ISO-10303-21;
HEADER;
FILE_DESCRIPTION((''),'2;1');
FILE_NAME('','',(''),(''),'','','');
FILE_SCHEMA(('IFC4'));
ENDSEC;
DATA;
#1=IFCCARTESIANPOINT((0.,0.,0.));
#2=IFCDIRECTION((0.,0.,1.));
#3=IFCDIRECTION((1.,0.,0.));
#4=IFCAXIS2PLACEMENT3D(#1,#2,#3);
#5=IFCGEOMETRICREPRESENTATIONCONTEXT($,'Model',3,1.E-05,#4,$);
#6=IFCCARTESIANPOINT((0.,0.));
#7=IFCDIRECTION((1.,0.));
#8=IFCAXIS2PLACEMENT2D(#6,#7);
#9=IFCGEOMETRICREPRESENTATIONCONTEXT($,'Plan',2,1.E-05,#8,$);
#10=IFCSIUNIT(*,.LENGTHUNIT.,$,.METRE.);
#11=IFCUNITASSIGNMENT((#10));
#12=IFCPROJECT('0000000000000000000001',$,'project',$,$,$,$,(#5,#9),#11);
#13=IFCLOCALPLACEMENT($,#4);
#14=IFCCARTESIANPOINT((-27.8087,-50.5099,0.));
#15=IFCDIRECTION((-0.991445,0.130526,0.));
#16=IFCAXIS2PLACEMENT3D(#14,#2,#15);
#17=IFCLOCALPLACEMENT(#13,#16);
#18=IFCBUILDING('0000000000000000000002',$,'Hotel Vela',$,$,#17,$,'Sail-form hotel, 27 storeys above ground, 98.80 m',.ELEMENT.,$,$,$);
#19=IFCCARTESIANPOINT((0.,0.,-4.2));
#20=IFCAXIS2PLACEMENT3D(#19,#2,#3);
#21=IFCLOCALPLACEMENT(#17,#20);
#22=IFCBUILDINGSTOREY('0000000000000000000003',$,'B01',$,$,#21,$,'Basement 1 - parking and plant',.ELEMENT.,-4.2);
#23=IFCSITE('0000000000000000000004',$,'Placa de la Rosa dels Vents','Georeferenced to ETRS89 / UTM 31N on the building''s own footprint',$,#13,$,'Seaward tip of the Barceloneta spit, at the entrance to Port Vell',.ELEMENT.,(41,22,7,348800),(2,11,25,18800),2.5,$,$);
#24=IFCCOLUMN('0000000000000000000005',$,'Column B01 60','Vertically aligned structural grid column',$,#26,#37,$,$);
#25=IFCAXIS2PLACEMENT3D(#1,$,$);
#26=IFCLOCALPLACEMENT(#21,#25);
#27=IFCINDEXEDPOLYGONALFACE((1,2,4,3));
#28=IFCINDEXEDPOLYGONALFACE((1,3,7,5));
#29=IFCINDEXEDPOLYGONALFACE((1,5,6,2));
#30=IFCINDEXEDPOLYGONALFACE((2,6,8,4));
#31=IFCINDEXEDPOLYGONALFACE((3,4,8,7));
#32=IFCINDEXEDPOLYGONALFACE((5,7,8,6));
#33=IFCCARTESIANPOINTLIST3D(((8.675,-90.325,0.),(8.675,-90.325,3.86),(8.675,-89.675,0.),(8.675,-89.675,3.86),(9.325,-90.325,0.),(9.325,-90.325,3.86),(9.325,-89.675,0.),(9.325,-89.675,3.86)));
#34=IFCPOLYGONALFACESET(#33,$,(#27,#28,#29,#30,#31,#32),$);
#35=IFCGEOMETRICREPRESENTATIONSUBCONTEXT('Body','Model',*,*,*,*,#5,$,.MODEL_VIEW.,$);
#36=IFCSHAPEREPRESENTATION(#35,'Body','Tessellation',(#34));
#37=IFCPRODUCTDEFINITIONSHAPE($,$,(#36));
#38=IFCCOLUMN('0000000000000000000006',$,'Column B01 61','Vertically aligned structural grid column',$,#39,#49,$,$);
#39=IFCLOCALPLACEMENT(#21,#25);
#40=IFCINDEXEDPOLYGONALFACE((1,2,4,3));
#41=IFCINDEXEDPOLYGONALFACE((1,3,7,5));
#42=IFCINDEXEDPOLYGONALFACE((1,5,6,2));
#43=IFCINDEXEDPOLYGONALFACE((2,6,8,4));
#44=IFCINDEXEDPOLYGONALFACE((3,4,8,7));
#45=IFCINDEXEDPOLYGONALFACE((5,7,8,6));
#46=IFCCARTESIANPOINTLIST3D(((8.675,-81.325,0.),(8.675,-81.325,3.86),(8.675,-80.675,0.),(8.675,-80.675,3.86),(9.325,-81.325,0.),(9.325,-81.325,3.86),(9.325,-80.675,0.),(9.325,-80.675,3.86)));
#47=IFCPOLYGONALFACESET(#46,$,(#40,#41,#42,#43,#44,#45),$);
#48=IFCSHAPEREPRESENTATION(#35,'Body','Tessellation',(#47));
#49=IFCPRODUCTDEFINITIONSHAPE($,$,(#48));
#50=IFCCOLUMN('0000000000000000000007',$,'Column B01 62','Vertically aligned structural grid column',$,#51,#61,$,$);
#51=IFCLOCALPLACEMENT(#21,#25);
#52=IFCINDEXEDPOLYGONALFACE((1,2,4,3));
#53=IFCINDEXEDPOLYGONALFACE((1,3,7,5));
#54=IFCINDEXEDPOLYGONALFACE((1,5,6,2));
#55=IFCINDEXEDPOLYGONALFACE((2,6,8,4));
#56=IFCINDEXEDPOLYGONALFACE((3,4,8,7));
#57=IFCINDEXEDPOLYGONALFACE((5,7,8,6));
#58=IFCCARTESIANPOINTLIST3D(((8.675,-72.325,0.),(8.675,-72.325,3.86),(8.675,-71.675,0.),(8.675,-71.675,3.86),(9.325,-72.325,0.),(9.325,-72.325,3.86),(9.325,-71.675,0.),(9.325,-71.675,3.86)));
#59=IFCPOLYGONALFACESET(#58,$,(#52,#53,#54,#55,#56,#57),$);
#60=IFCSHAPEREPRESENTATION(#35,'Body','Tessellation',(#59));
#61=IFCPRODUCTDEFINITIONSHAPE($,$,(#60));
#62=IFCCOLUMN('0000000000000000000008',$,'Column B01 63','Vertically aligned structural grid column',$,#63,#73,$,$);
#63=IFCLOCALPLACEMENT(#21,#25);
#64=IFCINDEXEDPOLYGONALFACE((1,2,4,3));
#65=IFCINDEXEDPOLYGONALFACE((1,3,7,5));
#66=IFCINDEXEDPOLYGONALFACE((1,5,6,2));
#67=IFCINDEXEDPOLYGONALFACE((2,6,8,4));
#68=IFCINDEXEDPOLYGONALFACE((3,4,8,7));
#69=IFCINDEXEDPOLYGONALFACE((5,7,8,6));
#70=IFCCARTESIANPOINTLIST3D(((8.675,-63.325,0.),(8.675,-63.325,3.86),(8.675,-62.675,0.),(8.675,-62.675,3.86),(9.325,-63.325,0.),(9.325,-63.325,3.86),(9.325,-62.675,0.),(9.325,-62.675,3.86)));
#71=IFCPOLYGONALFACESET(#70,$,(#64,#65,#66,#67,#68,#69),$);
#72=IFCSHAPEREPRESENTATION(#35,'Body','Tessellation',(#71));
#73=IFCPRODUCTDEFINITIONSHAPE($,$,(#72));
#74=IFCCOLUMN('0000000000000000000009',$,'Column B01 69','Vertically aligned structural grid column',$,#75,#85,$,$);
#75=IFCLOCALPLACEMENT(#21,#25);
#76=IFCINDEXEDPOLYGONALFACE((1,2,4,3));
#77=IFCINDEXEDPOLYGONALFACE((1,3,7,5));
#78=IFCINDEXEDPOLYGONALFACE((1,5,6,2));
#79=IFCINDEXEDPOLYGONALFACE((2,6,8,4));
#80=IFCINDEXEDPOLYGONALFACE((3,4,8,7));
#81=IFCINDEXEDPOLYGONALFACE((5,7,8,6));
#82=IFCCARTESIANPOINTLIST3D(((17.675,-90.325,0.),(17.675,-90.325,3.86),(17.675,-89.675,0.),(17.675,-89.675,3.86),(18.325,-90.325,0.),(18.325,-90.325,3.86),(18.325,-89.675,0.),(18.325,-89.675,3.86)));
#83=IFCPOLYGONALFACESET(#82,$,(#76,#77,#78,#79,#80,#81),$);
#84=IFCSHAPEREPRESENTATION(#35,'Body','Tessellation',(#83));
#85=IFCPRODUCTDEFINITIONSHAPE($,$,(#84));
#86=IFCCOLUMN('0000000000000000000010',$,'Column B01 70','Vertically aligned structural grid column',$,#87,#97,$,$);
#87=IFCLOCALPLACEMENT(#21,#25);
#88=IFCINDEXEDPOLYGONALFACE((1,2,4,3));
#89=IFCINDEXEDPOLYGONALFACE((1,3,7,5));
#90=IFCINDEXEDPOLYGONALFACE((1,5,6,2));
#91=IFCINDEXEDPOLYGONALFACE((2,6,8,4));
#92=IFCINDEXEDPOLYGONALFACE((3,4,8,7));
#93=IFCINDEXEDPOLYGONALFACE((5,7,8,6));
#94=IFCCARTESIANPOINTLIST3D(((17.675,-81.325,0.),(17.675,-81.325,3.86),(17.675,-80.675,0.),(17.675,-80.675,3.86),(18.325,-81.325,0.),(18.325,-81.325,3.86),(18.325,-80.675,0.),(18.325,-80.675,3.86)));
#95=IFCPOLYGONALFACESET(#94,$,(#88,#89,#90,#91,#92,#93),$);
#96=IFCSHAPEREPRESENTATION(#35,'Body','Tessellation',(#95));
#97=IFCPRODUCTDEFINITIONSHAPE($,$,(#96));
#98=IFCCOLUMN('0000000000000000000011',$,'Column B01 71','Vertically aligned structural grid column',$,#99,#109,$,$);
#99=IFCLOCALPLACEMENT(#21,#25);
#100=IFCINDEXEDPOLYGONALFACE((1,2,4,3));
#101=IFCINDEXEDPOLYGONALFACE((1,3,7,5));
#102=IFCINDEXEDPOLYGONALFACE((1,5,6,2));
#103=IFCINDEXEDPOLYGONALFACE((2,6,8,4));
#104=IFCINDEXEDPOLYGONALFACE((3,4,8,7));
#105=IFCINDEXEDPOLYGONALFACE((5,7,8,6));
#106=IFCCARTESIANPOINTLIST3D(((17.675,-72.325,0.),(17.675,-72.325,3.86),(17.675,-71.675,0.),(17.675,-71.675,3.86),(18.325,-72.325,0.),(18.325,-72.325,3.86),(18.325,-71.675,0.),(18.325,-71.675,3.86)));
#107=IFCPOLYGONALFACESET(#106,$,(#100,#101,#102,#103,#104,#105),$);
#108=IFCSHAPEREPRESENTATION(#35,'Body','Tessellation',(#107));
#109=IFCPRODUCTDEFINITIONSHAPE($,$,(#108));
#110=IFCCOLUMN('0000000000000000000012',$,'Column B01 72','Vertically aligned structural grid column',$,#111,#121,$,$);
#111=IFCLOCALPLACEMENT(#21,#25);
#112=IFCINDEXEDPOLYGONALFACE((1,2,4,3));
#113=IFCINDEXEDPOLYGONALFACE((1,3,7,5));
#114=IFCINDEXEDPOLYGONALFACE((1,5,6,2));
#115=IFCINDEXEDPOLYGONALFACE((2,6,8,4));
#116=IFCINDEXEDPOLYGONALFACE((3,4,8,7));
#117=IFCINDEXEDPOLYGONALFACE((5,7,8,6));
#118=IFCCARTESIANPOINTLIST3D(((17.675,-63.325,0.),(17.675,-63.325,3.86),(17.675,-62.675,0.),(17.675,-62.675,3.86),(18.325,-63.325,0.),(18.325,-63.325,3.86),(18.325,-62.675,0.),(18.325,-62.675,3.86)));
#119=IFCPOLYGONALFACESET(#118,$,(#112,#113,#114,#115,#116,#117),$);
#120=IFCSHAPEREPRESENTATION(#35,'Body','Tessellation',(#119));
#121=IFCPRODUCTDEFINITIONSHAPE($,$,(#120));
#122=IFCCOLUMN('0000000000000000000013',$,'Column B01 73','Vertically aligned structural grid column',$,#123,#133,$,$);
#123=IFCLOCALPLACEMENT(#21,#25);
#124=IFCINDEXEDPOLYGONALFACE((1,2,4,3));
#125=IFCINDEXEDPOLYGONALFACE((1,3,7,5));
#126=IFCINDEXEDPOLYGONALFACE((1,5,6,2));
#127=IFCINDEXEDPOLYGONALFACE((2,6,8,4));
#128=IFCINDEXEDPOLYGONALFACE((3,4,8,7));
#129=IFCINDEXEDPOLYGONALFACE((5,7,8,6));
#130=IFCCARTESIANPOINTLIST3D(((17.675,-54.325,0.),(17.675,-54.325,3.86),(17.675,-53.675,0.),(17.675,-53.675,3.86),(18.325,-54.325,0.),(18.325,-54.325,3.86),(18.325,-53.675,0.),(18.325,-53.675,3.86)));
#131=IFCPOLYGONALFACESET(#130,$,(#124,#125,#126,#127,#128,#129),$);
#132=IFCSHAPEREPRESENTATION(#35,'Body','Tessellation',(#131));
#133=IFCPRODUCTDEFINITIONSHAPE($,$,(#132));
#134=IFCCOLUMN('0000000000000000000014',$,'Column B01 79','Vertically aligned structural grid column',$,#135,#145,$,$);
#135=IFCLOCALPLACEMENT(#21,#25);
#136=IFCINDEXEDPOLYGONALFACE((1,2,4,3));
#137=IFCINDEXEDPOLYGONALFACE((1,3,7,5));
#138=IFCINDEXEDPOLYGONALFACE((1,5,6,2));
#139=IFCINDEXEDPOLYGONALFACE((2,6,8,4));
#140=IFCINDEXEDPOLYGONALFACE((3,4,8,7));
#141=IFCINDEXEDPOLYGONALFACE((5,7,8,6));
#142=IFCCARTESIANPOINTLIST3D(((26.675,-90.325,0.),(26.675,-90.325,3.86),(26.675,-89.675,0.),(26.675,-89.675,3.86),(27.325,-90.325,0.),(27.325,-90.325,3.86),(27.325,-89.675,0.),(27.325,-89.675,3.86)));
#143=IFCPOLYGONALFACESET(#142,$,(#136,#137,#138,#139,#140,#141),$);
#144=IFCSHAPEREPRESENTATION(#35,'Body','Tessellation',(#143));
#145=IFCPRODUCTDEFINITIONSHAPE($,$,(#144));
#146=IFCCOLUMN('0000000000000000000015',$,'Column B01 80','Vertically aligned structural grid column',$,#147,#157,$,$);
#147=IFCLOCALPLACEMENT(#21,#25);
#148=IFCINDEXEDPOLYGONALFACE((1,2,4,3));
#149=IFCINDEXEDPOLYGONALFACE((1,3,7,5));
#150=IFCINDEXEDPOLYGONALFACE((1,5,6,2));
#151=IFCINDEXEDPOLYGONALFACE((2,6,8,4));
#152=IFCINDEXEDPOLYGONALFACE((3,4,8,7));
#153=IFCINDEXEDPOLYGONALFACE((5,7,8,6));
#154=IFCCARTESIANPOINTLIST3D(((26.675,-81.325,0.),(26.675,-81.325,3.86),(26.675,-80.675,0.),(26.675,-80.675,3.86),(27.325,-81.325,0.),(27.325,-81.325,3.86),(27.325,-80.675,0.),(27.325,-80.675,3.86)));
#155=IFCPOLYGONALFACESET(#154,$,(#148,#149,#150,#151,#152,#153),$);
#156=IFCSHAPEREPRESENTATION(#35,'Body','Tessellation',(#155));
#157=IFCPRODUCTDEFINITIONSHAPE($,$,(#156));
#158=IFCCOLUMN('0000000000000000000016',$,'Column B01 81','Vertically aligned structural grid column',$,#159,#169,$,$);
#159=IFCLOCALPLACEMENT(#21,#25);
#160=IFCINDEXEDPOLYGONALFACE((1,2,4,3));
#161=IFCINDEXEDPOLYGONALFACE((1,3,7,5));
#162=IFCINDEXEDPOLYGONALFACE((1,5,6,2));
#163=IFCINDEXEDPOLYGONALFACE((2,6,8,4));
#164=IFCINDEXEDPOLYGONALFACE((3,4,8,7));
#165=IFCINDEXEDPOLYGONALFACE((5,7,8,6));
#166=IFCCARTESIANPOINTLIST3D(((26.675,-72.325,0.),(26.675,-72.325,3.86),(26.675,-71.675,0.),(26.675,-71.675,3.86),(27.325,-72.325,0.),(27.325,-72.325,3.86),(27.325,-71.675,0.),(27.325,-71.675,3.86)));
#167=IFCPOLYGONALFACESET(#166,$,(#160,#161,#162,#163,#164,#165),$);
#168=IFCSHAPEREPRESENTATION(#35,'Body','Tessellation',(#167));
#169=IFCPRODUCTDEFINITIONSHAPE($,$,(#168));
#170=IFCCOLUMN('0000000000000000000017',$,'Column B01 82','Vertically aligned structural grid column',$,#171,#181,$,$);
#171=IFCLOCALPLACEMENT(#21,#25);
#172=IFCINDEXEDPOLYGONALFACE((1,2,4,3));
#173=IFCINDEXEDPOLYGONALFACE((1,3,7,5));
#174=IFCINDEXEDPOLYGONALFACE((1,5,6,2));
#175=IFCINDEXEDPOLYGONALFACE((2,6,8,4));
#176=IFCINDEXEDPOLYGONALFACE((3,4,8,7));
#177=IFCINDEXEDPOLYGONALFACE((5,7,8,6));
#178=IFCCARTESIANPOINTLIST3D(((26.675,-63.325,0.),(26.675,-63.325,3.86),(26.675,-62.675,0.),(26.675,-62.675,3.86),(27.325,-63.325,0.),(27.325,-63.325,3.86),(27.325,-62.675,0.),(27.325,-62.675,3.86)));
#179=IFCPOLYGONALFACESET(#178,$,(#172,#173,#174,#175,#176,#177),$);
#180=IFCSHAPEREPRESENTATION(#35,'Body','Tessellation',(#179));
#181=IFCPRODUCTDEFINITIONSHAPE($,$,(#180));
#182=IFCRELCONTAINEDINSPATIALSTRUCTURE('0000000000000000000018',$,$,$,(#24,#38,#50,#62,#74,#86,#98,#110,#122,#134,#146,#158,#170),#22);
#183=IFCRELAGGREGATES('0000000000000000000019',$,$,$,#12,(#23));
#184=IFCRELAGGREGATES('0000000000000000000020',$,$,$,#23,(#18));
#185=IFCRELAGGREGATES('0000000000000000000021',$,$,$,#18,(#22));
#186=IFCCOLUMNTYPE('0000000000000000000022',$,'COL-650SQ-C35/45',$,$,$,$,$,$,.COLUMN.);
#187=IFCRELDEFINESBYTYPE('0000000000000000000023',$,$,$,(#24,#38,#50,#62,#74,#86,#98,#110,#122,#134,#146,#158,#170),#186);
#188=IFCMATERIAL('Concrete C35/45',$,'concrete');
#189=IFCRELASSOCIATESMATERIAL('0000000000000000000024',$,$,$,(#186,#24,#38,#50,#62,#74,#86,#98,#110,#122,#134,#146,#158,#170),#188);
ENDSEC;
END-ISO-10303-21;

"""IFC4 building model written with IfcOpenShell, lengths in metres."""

from ifc_helpers import new_model, si_unit, frame, origin_with_axes, origin_2d_with_axis, place, context, subcontext, project, spatial, line, indexed_curve, rectangle, outline, extrude, material, material_profile, profile_set, profile_usage, type_object, element, save


model = new_model("IFC4")

# Units and contexts
model_context = context("Model", 3, precision=1e-05, world=origin_with_axes())
plan_context = context("Plan", 2, precision=1e-05, world=origin_2d_with_axis())
body_context = subcontext(model_context, "Body", "Model", "MODEL_VIEW")
ifc_project = project(units=[si_unit("LENGTHUNIT", "METRE")], contexts=[model_context, plan_context])

# Site, building, storey
site_placement = place(None, origin_with_axes())
site = spatial("IfcSite", under=ifc_project, at=site_placement, Name="Placa de la Rosa dels Vents", Description="Georeferenced to ETRS89 / UTM 31N on the building's own footprint", LongName="Seaward tip of the Barceloneta spit, at the entrance to Port Vell", CompositionType="ELEMENT", RefLatitude=(41, 22, 7, 348800), RefLongitude=(2, 11, 25, 18800), RefElevation=2.5)
building_placement = place(site_placement, frame((-27.8087, -50.5099, 0.0), z_axis=(0.0, 0.0, 1.0), x_axis=(-0.991445, 0.130526, 0.0)))
building = spatial("IfcBuilding", under=site, at=building_placement, Name="Hotel Vela", LongName="Sail-form hotel, 27 storeys above ground, 98.80 m", CompositionType="ELEMENT")
storey_placement = place(building_placement, frame((0.0, 0.0, -4.2), z_axis=(0.0, 0.0, 1.0), x_axis=(1.0, 0.0, 0.0)))
storey = spatial("IfcBuildingStorey", under=building, at=storey_placement, Name="B01", LongName="Basement 1 - parking and plant", CompositionType="ELEMENT", Elevation=-4.2)

# Columns
ifc_material = material(Name="Concrete C35/45", Category="concrete")
ifc_material_profile = material_profile(ifc_material, rectangle(XDim=0.65, YDim=0.65))
ifc_profile_set = profile_set([ifc_material_profile], Name="COL-650SQ-C35/45")
ifc_profile_usage_1 = profile_usage(ifc_profile_set)
column_type = type_object("IfcColumnType", Name="COL-650SQ-C35/45", PredefinedType="COLUMN", material=ifc_profile_set)
column_1_placement = place(storey_placement, frame((8.675, -90.325, 0.0), z_axis=(0.0, 0.0, 1.0), x_axis=(1.0, 0.0, 0.0)))
element("IfcColumn", 1, at=column_1_placement, inside=storey, type_object=column_type, material=ifc_profile_usage_1, Name="Column B01 60", Description="Vertically aligned structural grid column", context=body_context, shape_type="SweptSolid", body=[
    extrude(outline(indexed_curve([(0.0, 0.0), (0.65, 0.0), (0.65, 0.65), (0.0, 0.65)], segments=[line(1, 2, 3, 4, 1)])), origin_with_axes(), (0.0, 0.0, 1.0), 3.86),
])
ifc_profile_usage_2 = profile_usage(ifc_profile_set)
column_2_placement = place(storey_placement, frame((8.675, -81.325, 0.0), z_axis=(0.0, 0.0, 1.0), x_axis=(1.0, 0.0, 0.0)))
element("IfcColumn", 2, at=column_2_placement, inside=storey, type_object=column_type, material=ifc_profile_usage_2, Name="Column B01 61", Description="Vertically aligned structural grid column", context=body_context, shape_type="SweptSolid", body=[
    extrude(outline(indexed_curve([(0.0, 0.0), (0.65, 0.0), (0.65, 0.65), (0.0, 0.65)], segments=[line(1, 2, 3, 4, 1)])), origin_with_axes(), (0.0, 0.0, 1.0), 3.86),
])
ifc_profile_usage_3 = profile_usage(ifc_profile_set)
column_3_placement = place(storey_placement, frame((8.675, -72.325, 0.0), z_axis=(0.0, 0.0, 1.0), x_axis=(1.0, 0.0, 0.0)))
element("IfcColumn", 3, at=column_3_placement, inside=storey, type_object=column_type, material=ifc_profile_usage_3, Name="Column B01 62", Description="Vertically aligned structural grid column", context=body_context, shape_type="SweptSolid", body=[
    extrude(outline(indexed_curve([(0.0, 0.0), (0.65, 0.0), (0.65, 0.65), (0.0, 0.65)], segments=[line(1, 2, 3, 4, 1)])), origin_with_axes(), (0.0, 0.0, 1.0), 3.86),
])
ifc_profile_usage_4 = profile_usage(ifc_profile_set)
column_4_placement = place(storey_placement, frame((8.675, -63.325, 0.0), z_axis=(0.0, 0.0, 1.0), x_axis=(1.0, 0.0, 0.0)))
element("IfcColumn", 4, at=column_4_placement, inside=storey, type_object=column_type, material=ifc_profile_usage_4, Name="Column B01 63", Description="Vertically aligned structural grid column", context=body_context, shape_type="SweptSolid", body=[
    extrude(outline(indexed_curve([(0.0, 0.0), (0.65, 0.0), (0.65, 0.65), (0.0, 0.65)], segments=[line(1, 2, 3, 4, 1)])), origin_with_axes(), (0.0, 0.0, 1.0), 3.86),
])
ifc_profile_usage_5 = profile_usage(ifc_profile_set)
column_5_placement = place(storey_placement, frame((17.675, -90.325, 0.0), z_axis=(0.0, 0.0, 1.0), x_axis=(1.0, 0.0, 0.0)))
element("IfcColumn", 5, at=column_5_placement, inside=storey, type_object=column_type, material=ifc_profile_usage_5, Name="Column B01 69", Description="Vertically aligned structural grid column", context=body_context, shape_type="SweptSolid", body=[
    extrude(outline(indexed_curve([(0.0, 0.0), (0.65, 0.0), (0.65, 0.65), (0.0, 0.65)], segments=[line(1, 2, 3, 4, 1)])), origin_with_axes(), (0.0, 0.0, 1.0), 3.86),
])
ifc_profile_usage_6 = profile_usage(ifc_profile_set)
column_6_placement = place(storey_placement, frame((17.675, -81.325, 0.0), z_axis=(0.0, 0.0, 1.0), x_axis=(1.0, 0.0, 0.0)))
element("IfcColumn", 6, at=column_6_placement, inside=storey, type_object=column_type, material=ifc_profile_usage_6, Name="Column B01 70", Description="Vertically aligned structural grid column", context=body_context, shape_type="SweptSolid", body=[
    extrude(outline(indexed_curve([(0.0, 0.0), (0.65, 0.0), (0.65, 0.65), (0.0, 0.65)], segments=[line(1, 2, 3, 4, 1)])), origin_with_axes(), (0.0, 0.0, 1.0), 3.86),
])
ifc_profile_usage_7 = profile_usage(ifc_profile_set)
column_7_placement = place(storey_placement, frame((17.675, -72.325, 0.0), z_axis=(0.0, 0.0, 1.0), x_axis=(1.0, 0.0, 0.0)))
element("IfcColumn", 7, at=column_7_placement, inside=storey, type_object=column_type, material=ifc_profile_usage_7, Name="Column B01 71", Description="Vertically aligned structural grid column", context=body_context, shape_type="SweptSolid", body=[
    extrude(outline(indexed_curve([(0.0, 0.0), (0.65, 0.0), (0.65, 0.65), (0.0, 0.65)], segments=[line(1, 2, 3, 4, 1)])), origin_with_axes(), (0.0, 0.0, 1.0), 3.86),
])
ifc_profile_usage_8 = profile_usage(ifc_profile_set)
column_8_placement = place(storey_placement, frame((17.675, -63.325, 0.0), z_axis=(0.0, 0.0, 1.0), x_axis=(1.0, 0.0, 0.0)))
element("IfcColumn", 8, at=column_8_placement, inside=storey, type_object=column_type, material=ifc_profile_usage_8, Name="Column B01 72", Description="Vertically aligned structural grid column", context=body_context, shape_type="SweptSolid", body=[
    extrude(outline(indexed_curve([(0.0, 0.0), (0.65, 0.0), (0.65, 0.65), (0.0, 0.65)], segments=[line(1, 2, 3, 4, 1)])), origin_with_axes(), (0.0, 0.0, 1.0), 3.86),
])
ifc_profile_usage_9 = profile_usage(ifc_profile_set)
column_9_placement = place(storey_placement, frame((17.675, -54.325, 0.0), z_axis=(0.0, 0.0, 1.0), x_axis=(1.0, 0.0, 0.0)))
element("IfcColumn", 9, at=column_9_placement, inside=storey, type_object=column_type, material=ifc_profile_usage_9, Name="Column B01 73", Description="Vertically aligned structural grid column", context=body_context, shape_type="SweptSolid", body=[
    extrude(outline(indexed_curve([(0.0, 0.0), (0.65, 0.0), (0.65, 0.65), (0.0, 0.65)], segments=[line(1, 2, 3, 4, 1)])), origin_with_axes(), (0.0, 0.0, 1.0), 3.86),
])
ifc_profile_usage_10 = profile_usage(ifc_profile_set)
column_10_placement = place(storey_placement, frame((26.675, -90.325, 0.0), z_axis=(0.0, 0.0, 1.0), x_axis=(1.0, 0.0, 0.0)))
element("IfcColumn", 10, at=column_10_placement, inside=storey, type_object=column_type, material=ifc_profile_usage_10, Name="Column B01 79", Description="Vertically aligned structural grid column", context=body_context, shape_type="SweptSolid", body=[
    extrude(outline(indexed_curve([(0.0, 0.0), (0.65, 0.0), (0.65, 0.65), (0.0, 0.65)], segments=[line(1, 2, 3, 4, 1)])), origin_with_axes(), (0.0, 0.0, 1.0), 3.86),
])
ifc_profile_usage_11 = profile_usage(ifc_profile_set)
column_11_placement = place(storey_placement, frame((26.675, -81.325, 0.0), z_axis=(0.0, 0.0, 1.0), x_axis=(1.0, 0.0, 0.0)))
element("IfcColumn", 11, at=column_11_placement, inside=storey, type_object=column_type, material=ifc_profile_usage_11, Name="Column B01 80", Description="Vertically aligned structural grid column", context=body_context, shape_type="SweptSolid", body=[
    extrude(outline(indexed_curve([(0.0, 0.0), (0.65, 0.0), (0.65, 0.65), (0.0, 0.65)], segments=[line(1, 2, 3, 4, 1)])), origin_with_axes(), (0.0, 0.0, 1.0), 3.86),
])
ifc_profile_usage_12 = profile_usage(ifc_profile_set)
column_12_placement = place(storey_placement, frame((26.675, -72.325, 0.0), z_axis=(0.0, 0.0, 1.0), x_axis=(1.0, 0.0, 0.0)))
element("IfcColumn", 12, at=column_12_placement, inside=storey, type_object=column_type, material=ifc_profile_usage_12, Name="Column B01 81", Description="Vertically aligned structural grid column", context=body_context, shape_type="SweptSolid", body=[
    extrude(outline(indexed_curve([(0.0, 0.0), (0.65, 0.0), (0.65, 0.65), (0.0, 0.65)], segments=[line(1, 2, 3, 4, 1)])), origin_with_axes(), (0.0, 0.0, 1.0), 3.86),
])
ifc_profile_usage_13 = profile_usage(ifc_profile_set)
column_13_placement = place(storey_placement, frame((26.675, -63.325, 0.0), z_axis=(0.0, 0.0, 1.0), x_axis=(1.0, 0.0, 0.0)))
element("IfcColumn", 13, at=column_13_placement, inside=storey, type_object=column_type, material=ifc_profile_usage_13, Name="Column B01 82", Description="Vertically aligned structural grid column", context=body_context, shape_type="SweptSolid", body=[
    extrude(outline(indexed_curve([(0.0, 0.0), (0.65, 0.0), (0.65, 0.65), (0.0, 0.65)], segments=[line(1, 2, 3, 4, 1)])), origin_with_axes(), (0.0, 0.0, 1.0), 3.86),
])

save(model, "model.ifc")
